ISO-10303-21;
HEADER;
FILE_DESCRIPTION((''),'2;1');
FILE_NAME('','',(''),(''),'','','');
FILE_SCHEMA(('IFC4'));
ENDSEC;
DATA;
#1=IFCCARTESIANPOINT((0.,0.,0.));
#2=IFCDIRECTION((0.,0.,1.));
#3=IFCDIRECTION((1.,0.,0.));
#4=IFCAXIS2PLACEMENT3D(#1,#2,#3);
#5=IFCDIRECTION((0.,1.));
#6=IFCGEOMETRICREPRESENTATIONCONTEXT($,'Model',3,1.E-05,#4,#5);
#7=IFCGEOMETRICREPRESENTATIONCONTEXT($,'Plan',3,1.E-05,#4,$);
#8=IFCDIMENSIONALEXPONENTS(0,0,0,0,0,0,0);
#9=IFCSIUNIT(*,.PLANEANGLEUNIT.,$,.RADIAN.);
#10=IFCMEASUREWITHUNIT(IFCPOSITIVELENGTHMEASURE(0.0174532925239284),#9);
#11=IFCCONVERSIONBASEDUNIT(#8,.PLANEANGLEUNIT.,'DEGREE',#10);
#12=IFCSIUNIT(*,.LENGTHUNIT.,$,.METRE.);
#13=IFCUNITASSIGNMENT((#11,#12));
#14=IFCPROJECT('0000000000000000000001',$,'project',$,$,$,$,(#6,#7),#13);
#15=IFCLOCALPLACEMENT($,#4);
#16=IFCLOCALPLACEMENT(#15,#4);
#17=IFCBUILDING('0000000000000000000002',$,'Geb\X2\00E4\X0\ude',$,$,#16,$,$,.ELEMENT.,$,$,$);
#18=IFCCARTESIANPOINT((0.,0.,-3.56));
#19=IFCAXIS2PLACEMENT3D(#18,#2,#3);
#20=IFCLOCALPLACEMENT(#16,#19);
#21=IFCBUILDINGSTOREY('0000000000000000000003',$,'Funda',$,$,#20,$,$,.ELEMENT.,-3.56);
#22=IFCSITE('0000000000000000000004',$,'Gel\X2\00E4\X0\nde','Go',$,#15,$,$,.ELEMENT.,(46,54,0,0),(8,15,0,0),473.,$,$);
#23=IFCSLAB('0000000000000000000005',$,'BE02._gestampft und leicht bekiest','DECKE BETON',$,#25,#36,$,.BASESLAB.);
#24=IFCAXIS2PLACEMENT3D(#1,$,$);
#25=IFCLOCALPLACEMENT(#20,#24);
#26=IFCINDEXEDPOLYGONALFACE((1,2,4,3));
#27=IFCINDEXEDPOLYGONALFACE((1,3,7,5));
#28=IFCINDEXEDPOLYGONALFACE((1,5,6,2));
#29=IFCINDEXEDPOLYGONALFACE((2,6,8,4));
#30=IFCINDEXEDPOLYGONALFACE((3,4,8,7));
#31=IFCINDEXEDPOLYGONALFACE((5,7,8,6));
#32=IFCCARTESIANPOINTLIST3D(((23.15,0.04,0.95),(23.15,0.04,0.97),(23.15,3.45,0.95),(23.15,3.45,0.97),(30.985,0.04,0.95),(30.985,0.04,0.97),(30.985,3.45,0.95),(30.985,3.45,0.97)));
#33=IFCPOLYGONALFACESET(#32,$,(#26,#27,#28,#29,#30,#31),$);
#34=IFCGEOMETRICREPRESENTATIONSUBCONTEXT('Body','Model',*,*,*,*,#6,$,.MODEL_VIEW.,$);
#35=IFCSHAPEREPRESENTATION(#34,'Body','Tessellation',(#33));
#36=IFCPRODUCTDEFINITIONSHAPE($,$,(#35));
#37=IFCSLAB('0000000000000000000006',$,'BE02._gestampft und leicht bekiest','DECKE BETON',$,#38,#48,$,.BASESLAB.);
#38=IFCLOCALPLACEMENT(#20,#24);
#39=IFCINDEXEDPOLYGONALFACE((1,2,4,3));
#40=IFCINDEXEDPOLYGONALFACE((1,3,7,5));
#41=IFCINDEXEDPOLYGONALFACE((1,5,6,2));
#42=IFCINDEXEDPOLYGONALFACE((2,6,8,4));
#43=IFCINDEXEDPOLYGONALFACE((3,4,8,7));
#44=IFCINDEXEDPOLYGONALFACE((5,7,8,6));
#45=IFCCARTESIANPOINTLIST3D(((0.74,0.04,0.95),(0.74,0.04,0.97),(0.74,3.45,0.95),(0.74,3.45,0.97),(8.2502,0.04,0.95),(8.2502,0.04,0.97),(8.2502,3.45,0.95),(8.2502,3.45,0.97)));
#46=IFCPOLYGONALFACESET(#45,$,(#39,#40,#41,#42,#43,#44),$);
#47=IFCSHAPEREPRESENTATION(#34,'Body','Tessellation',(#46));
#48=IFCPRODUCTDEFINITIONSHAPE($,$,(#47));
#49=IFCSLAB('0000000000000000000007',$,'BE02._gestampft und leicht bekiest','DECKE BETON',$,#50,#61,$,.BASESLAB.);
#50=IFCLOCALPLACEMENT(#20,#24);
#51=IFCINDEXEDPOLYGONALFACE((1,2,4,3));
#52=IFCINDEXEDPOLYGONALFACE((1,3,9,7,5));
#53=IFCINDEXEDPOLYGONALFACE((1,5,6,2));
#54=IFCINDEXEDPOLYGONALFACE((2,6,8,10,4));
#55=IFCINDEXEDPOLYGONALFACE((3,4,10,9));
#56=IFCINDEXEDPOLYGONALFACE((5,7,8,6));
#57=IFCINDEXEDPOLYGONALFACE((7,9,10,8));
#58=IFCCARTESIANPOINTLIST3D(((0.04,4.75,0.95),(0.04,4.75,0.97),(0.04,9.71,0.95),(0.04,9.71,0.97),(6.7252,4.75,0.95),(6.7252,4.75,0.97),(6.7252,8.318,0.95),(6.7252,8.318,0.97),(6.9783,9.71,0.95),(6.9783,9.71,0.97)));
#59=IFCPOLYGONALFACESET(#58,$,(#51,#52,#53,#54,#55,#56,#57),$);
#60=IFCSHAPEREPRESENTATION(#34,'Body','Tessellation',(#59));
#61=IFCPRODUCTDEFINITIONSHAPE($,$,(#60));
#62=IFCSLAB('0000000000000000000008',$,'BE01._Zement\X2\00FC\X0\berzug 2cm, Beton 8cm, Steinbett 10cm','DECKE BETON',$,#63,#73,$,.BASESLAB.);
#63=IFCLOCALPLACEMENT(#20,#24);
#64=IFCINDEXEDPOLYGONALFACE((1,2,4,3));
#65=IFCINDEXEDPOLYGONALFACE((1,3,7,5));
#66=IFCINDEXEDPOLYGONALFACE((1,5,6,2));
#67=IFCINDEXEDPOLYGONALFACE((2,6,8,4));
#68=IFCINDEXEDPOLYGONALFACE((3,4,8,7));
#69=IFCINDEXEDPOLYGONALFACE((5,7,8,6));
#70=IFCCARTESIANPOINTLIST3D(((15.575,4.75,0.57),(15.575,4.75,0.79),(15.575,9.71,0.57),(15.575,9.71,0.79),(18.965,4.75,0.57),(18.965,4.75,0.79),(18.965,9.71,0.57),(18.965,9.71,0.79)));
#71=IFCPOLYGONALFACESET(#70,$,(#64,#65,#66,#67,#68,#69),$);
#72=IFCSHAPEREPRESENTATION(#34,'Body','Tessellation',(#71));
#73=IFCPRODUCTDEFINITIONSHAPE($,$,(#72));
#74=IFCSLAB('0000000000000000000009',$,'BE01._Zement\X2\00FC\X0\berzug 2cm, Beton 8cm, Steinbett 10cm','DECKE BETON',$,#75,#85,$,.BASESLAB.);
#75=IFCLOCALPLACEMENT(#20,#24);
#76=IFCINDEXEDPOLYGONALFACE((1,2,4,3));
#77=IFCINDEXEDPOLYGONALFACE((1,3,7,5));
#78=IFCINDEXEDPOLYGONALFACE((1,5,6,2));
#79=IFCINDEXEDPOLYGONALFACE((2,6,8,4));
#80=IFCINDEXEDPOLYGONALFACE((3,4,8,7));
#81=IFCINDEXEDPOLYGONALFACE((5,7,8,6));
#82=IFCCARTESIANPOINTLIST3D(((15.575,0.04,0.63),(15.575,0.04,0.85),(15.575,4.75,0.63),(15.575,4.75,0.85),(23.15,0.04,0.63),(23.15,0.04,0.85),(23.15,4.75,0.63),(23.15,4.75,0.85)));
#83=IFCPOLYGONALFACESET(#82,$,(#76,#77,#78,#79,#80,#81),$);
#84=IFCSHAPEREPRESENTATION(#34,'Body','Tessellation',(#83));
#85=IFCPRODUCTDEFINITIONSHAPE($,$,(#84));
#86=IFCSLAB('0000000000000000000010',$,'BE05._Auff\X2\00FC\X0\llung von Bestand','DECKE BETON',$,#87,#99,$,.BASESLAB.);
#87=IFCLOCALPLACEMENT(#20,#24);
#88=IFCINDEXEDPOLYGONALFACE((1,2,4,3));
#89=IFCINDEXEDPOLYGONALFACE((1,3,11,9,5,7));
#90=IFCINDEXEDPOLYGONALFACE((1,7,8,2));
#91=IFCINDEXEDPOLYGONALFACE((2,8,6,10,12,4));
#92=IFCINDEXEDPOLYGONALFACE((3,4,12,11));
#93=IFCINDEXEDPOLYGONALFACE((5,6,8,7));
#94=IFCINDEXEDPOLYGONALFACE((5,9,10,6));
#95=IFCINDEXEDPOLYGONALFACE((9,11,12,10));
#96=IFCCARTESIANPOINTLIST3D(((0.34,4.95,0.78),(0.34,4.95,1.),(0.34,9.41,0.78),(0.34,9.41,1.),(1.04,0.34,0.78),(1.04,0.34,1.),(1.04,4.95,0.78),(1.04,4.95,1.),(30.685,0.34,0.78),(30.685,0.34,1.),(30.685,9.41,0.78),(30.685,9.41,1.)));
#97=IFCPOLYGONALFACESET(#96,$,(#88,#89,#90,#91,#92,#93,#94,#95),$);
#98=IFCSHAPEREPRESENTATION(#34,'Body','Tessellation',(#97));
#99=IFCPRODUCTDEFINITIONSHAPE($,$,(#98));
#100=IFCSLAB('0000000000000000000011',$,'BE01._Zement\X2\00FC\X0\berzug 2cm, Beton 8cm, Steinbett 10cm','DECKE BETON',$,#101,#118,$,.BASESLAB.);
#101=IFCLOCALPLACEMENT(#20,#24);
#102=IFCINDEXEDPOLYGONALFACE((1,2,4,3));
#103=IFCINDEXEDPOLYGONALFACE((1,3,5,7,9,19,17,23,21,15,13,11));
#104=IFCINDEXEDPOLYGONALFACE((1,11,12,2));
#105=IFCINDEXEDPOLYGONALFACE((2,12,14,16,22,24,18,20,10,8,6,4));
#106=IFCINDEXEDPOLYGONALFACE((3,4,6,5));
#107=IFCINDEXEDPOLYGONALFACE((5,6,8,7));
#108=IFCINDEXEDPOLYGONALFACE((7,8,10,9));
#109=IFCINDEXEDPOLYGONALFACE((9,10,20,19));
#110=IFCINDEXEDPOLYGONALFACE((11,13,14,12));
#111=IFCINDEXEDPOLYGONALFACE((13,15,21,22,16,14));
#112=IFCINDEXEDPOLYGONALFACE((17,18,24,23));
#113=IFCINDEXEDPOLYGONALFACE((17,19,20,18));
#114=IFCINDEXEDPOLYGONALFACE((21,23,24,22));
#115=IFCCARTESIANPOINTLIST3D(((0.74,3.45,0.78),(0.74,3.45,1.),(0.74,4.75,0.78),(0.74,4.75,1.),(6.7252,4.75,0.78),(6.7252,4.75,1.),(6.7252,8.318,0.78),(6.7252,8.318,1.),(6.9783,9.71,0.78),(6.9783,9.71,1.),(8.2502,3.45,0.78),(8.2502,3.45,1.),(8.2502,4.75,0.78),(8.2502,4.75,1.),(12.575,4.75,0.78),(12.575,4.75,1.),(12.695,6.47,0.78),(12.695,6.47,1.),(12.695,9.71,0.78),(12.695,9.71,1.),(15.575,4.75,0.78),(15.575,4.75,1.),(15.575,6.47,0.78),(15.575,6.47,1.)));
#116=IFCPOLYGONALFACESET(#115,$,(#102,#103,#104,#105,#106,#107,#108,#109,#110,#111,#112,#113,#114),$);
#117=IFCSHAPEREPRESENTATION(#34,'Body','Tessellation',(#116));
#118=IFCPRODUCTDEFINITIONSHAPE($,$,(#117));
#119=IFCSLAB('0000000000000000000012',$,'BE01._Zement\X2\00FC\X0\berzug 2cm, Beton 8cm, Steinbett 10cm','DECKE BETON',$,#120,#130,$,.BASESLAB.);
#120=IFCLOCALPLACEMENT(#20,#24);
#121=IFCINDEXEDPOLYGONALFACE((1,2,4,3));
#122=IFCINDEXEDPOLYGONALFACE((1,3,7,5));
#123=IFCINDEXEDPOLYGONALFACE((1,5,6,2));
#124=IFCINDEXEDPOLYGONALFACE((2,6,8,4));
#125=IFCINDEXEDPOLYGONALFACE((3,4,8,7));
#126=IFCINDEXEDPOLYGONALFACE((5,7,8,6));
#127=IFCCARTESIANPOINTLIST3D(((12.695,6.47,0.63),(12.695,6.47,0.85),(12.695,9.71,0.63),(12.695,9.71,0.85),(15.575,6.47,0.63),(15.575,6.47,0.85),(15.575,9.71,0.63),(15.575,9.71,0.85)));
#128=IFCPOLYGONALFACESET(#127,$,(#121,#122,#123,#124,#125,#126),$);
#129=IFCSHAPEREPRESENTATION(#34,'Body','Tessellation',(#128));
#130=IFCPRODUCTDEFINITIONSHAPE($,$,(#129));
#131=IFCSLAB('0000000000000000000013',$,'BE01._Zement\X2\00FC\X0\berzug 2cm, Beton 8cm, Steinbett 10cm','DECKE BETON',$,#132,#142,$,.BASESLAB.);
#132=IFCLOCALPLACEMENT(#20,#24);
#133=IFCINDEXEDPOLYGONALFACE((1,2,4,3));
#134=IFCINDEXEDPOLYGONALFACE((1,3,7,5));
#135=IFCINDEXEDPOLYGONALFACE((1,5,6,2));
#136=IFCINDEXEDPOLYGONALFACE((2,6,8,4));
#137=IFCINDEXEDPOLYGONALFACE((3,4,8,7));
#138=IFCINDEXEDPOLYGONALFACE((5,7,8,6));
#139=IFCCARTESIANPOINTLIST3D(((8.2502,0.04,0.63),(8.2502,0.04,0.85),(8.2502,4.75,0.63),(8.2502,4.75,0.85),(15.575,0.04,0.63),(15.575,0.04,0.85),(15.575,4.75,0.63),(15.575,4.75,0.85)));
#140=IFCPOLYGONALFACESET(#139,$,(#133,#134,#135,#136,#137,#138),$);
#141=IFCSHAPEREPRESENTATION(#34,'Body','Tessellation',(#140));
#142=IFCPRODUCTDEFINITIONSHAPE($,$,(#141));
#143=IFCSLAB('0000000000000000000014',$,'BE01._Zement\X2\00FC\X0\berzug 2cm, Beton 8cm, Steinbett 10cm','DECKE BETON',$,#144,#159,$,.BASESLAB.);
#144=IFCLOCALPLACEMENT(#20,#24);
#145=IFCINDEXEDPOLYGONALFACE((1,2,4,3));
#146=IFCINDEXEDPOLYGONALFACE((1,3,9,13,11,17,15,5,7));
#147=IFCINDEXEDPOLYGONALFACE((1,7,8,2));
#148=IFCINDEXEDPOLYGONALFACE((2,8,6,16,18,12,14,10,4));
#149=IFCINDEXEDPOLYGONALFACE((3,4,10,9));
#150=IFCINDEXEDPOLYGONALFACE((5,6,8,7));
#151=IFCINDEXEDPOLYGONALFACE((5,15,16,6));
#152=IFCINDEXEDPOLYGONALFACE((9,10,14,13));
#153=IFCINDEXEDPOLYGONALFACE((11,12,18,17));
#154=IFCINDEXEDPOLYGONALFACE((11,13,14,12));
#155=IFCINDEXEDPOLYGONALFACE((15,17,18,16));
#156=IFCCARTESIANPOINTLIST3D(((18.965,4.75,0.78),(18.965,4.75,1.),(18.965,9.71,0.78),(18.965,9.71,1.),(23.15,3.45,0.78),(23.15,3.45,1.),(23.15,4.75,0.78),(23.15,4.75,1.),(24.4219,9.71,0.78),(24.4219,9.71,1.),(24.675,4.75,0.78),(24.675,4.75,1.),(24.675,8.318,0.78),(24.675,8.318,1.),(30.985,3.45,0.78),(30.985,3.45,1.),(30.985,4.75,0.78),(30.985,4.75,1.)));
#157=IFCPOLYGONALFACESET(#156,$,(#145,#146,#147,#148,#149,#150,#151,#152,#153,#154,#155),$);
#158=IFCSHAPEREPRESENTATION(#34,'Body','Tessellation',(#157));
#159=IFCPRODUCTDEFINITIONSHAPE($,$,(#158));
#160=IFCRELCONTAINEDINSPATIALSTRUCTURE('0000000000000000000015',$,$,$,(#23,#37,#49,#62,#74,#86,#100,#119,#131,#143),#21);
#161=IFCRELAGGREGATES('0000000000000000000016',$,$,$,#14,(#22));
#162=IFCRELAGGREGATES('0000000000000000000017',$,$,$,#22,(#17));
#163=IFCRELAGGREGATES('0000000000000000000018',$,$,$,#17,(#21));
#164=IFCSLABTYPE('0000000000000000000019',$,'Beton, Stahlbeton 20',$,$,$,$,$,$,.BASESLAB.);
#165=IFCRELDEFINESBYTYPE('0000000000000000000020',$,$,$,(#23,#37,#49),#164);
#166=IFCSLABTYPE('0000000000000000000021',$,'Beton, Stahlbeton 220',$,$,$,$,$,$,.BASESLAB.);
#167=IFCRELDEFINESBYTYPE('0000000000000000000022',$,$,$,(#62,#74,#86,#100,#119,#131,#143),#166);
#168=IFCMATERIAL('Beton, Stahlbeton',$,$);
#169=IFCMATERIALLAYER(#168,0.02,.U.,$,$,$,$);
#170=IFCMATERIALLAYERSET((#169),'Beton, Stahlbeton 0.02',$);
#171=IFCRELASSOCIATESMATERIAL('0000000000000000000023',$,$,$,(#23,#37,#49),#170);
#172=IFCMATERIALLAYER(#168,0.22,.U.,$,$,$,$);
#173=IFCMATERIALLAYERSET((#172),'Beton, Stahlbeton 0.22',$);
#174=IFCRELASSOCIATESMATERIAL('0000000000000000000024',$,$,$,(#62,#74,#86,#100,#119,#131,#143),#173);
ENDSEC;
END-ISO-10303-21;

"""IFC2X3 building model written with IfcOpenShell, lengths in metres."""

from ifc_helpers import new_model, entity, si_unit, converted_unit, direction, frame, origin_with_axes, place, context, subcontext, project, spatial, polyline, outline, extrude, material, layer, layer_set, layer_usage, type_object, element, save


model = new_model("IFC2X3")

# Units and contexts
model_context = context("Model", 3, precision=1e-05, world=origin_with_axes(), true_north=direction((0.0, 1.0)))
plan_context = context("Plan", 3, precision=1e-05, world=origin_with_axes())
body_context = subcontext(model_context, "Body", "Model", "MODEL_VIEW")
ifc_project = project(units=[converted_unit("PLANEANGLEUNIT", "DEGREE", entity("IfcPositiveLengthMeasure", 0.0174532925239284), si_unit("PLANEANGLEUNIT", "RADIAN"), dimensions=[0, 0, 0, 0, 0, 0, 0]), si_unit("LENGTHUNIT", "METRE")], contexts=[model_context, plan_context])

# Site, building, storey
site_placement = place(None, origin_with_axes())
site = spatial("IfcSite", under=ifc_project, at=site_placement, Name="Gelände", Description="Go", CompositionType="ELEMENT", RefLatitude=(46, 54, 0, 0), RefLongitude=(8, 15, 0, 0), RefElevation=473.0)
building_placement = place(site_placement, origin_with_axes())
building = spatial("IfcBuilding", under=site, at=building_placement, Name="Gebäude", CompositionType="ELEMENT")
storey_placement = place(building_placement, frame((0.0, 0.0, -3.56), z_axis=(0.0, 0.0, 1.0), x_axis=(1.0, 0.0, 0.0)))
storey = spatial("IfcBuildingStorey", under=building, at=storey_placement, Name="Funda", CompositionType="ELEMENT", Elevation=-3.56)

# Shared definitions
ifc_material = material(Name="Beton, Stahlbeton")

# Slabs
ifc_layer_1 = layer(ifc_material, 0.02, ventilated="UNKNOWN")
ifc_layer_set_1 = layer_set([ifc_layer_1], Name="Beton, Stahlbeton 0.02")
slab_type_1 = type_object("IfcSlabType", Name="Beton, Stahlbeton 20", PredefinedType="BASESLAB")
ifc_layer_usage_1 = layer_usage(ifc_layer_set_1, "AXIS3", "NEGATIVE", 0.02)
slab_1_placement = place(storey_placement, frame((23.15, 3.45, 0.97), z_axis=(0.0, 0.0, 1.0), x_axis=(1.0, 0.0, 0.0)))
element("IfcSlab", 1, at=slab_1_placement, inside=storey, type_object=slab_type_1, material=ifc_layer_usage_1, Name="BE02._gestampft und leicht bekiest", Description="DECKE BETON", PredefinedType="BASESLAB", context=body_context, shape_type="SweptSolid", body=[
    extrude(outline(polyline([(0.0, 0.0), (0.0, -3.41), (7.835, -3.41), (7.835, 0.0), (0.0, 0.0)])), frame((0.0, 0.0, -0.02), z_axis=(0.0, 0.0, 1.0), x_axis=(1.0, 0.0, 0.0)), (0.0, 0.0, 1.0), 0.02),
])
ifc_layer_usage_2 = layer_usage(ifc_layer_set_1, "AXIS3", "NEGATIVE", 0.02)
slab_2_placement = place(storey_placement, frame((0.74, 3.45, 0.97), z_axis=(0.0, 0.0, 1.0), x_axis=(1.0, 0.0, 0.0)))
element("IfcSlab", 2, at=slab_2_placement, inside=storey, type_object=slab_type_1, material=ifc_layer_usage_2, Name="BE02._gestampft und leicht bekiest", Description="DECKE BETON", PredefinedType="BASESLAB", context=body_context, shape_type="SweptSolid", body=[
    extrude(outline(polyline([(0.0, 0.0), (0.0, -3.41), (7.5102, -3.41), (7.5102, 0.0), (0.0, 0.0)])), frame((0.0, 0.0, -0.02), z_axis=(0.0, 0.0, 1.0), x_axis=(1.0, 0.0, 0.0)), (0.0, 0.0, 1.0), 0.02),
])
ifc_layer_usage_3 = layer_usage(ifc_layer_set_1, "AXIS3", "NEGATIVE", 0.02)
slab_3_placement = place(storey_placement, frame((6.9783, 9.71, 0.97), z_axis=(0.0, 0.0, 1.0), x_axis=(1.0, 0.0, 0.0)))
element("IfcSlab", 3, at=slab_3_placement, inside=storey, type_object=slab_type_1, material=ifc_layer_usage_3, Name="BE02._gestampft und leicht bekiest", Description="DECKE BETON", PredefinedType="BASESLAB", context=body_context, shape_type="SweptSolid", body=[
    extrude(outline(polyline([(0.0, 0.0), (-6.9383, 0.0), (-6.9383, -4.96), (-0.2531, -4.96), (-0.2531, -1.392), (0.0, 0.0)])), frame((0.0, 0.0, -0.02), z_axis=(0.0, 0.0, 1.0), x_axis=(1.0, 0.0, 0.0)), (0.0, 0.0, 1.0), 0.02),
])
ifc_layer_2 = layer(ifc_material, 0.22, ventilated="UNKNOWN")
ifc_layer_set_2 = layer_set([ifc_layer_2], Name="Beton, Stahlbeton 0.22")
ifc_layer_usage_4 = layer_usage(ifc_layer_set_2, "AXIS3", "NEGATIVE", 0.22)
slab_type_2 = type_object("IfcSlabType", Name="Beton, Stahlbeton 220", PredefinedType="BASESLAB")
slab_4_placement = place(storey_placement, frame((15.575, 4.75, 0.79), z_axis=(0.0, 0.0, 1.0), x_axis=(1.0, 0.0, 0.0)))
element("IfcSlab", 4, at=slab_4_placement, inside=storey, type_object=slab_type_2, material=ifc_layer_usage_4, Name="BE01._Zementüberzug 2cm, Beton 8cm, Steinbett 10cm", Description="DECKE BETON", PredefinedType="BASESLAB", context=body_context, shape_type="SweptSolid", body=[
    extrude(outline(polyline([(0.0, 0.0), (3.39, 0.0), (3.39, 4.96), (0.0, 4.96), (0.0, 0.0)])), frame((0.0, 0.0, -0.22), z_axis=(0.0, 0.0, 1.0), x_axis=(1.0, 0.0, 0.0)), (0.0, 0.0, 1.0), 0.22),
])
ifc_layer_usage_5 = layer_usage(ifc_layer_set_2, "AXIS3", "NEGATIVE", 0.22)
slab_5_placement = place(storey_placement, frame((15.575, 0.04, 0.85), z_axis=(0.0, 0.0, 1.0), x_axis=(1.0, 0.0, 0.0)))
element("IfcSlab", 5, at=slab_5_placement, inside=storey, type_object=slab_type_2, material=ifc_layer_usage_5, Name="BE01._Zementüberzug 2cm, Beton 8cm, Steinbett 10cm", Description="DECKE BETON", PredefinedType="BASESLAB", context=body_context, shape_type="SweptSolid", body=[
    extrude(outline(polyline([(0.0, 0.0), (7.575, 0.0), (7.575, 4.71), (0.0, 4.71), (0.0, 0.0)])), frame((0.0, 0.0, -0.22), z_axis=(0.0, 0.0, 1.0), x_axis=(1.0, 0.0, 0.0)), (0.0, 0.0, 1.0), 0.22),
])
ifc_layer_usage_6 = layer_usage(ifc_layer_set_2, "AXIS3", "NEGATIVE", 0.22)
slab_6_placement = place(storey_placement, frame((0.34, 9.41, 1.0), z_axis=(0.0, 0.0, 1.0), x_axis=(1.0, 0.0, 0.0)))
element("IfcSlab", 6, at=slab_6_placement, inside=storey, type_object=slab_type_2, material=ifc_layer_usage_6, Name="BE05._Auffüllung von Bestand", Description="DECKE BETON", PredefinedType="BASESLAB", context=body_context, shape_type="SweptSolid", body=[
    extrude(outline(polyline([(0.0, 0.0), (0.0, -4.46), (0.7, -4.46), (0.7, -9.07), (30.345, -9.07), (30.345, 0.0), (0.0, 0.0)])), frame((0.0, 0.0, -0.22), z_axis=(0.0, 0.0, 1.0), x_axis=(1.0, 0.0, 0.0)), (0.0, 0.0, 1.0), 0.22),
])
ifc_layer_usage_7 = layer_usage(ifc_layer_set_2, "AXIS3", "NEGATIVE", 0.22)
slab_7_placement = place(storey_placement, frame((6.7252, 4.75, 1.0), z_axis=(0.0, 0.0, 1.0), x_axis=(1.0, 0.0, 0.0)))
element("IfcSlab", 7, at=slab_7_placement, inside=storey, type_object=slab_type_2, material=ifc_layer_usage_7, Name="BE01._Zementüberzug 2cm, Beton 8cm, Steinbett 10cm", Description="DECKE BETON", PredefinedType="BASESLAB", context=body_context, shape_type="SweptSolid", body=[
    extrude(outline(polyline([(0.0, 0.0), (-5.9852, 0.0), (-5.9852, -1.3), (1.525, -1.3), (1.525, 0.0), (5.8498, 0.0), (8.8498, 0.0), (8.8498, 1.72), (5.9698, 1.72), (5.9698, 4.96), (0.2531, 4.96), (0.0, 3.568), (0.0, 0.0)])), frame((0.0, 0.0, -0.22), z_axis=(0.0, 0.0, 1.0), x_axis=(1.0, 0.0, 0.0)), (0.0, 0.0, 1.0), 0.22),
])
ifc_layer_usage_8 = layer_usage(ifc_layer_set_2, "AXIS3", "NEGATIVE", 0.22)
slab_8_placement = place(storey_placement, frame((15.575, 6.47, 0.85), z_axis=(0.0, 0.0, 1.0), x_axis=(1.0, 0.0, 0.0)))
element("IfcSlab", 8, at=slab_8_placement, inside=storey, type_object=slab_type_2, material=ifc_layer_usage_8, Name="BE01._Zementüberzug 2cm, Beton 8cm, Steinbett 10cm", Description="DECKE BETON", PredefinedType="BASESLAB", context=body_context, shape_type="SweptSolid", body=[
    extrude(outline(polyline([(0.0, 0.0), (0.0, 3.24), (-2.88, 3.24), (-2.88, 0.0), (0.0, 0.0)])), frame((0.0, 0.0, -0.22), z_axis=(0.0, 0.0, 1.0), x_axis=(1.0, 0.0, 0.0)), (0.0, 0.0, 1.0), 0.22),
])
ifc_layer_usage_9 = layer_usage(ifc_layer_set_2, "AXIS3", "NEGATIVE", 0.22)
slab_9_placement = place(storey_placement, frame((15.575, 0.04, 0.85), z_axis=(0.0, 0.0, 1.0), x_axis=(1.0, 0.0, 0.0)))
element("IfcSlab", 9, at=slab_9_placement, inside=storey, type_object=slab_type_2, material=ifc_layer_usage_9, Name="BE01._Zementüberzug 2cm, Beton 8cm, Steinbett 10cm", Description="DECKE BETON", PredefinedType="BASESLAB", context=body_context, shape_type="SweptSolid", body=[
    extrude(outline(polyline([(0.0, 0.0), (0.0, 4.71), (-7.3248, 4.71), (-7.3248, 0.0), (0.0, 0.0)])), frame((0.0, 0.0, -0.22), z_axis=(0.0, 0.0, 1.0), x_axis=(1.0, 0.0, 0.0)), (0.0, 0.0, 1.0), 0.22),
])
ifc_layer_usage_10 = layer_usage(ifc_layer_set_2, "AXIS3", "NEGATIVE", 0.22)
slab_10_placement = place(storey_placement, frame((24.4219, 9.71, 1.0), z_axis=(0.0, 0.0, 1.0), x_axis=(1.0, 0.0, 0.0)))
element("IfcSlab", 10, at=slab_10_placement, inside=storey, type_object=slab_type_2, material=ifc_layer_usage_10, Name="BE01._Zementüberzug 2cm, Beton 8cm, Steinbett 10cm", Description="DECKE BETON", PredefinedType="BASESLAB", context=body_context, shape_type="SweptSolid", body=[
    extrude(outline(polyline([(0.0, 0.0), (-5.4569, 0.0), (-5.4569, -4.96), (-1.2719, -4.96), (-1.2719, -6.26), (6.5631, -6.26), (6.5631, -4.96), (0.2531, -4.96), (0.2531, -1.392), (0.0, 0.0)])), frame((0.0, 0.0, -0.22), z_axis=(0.0, 0.0, 1.0), x_axis=(1.0, 0.0, 0.0)), (0.0, 0.0, 1.0), 0.22),
])

save(model, "model.ifc")
